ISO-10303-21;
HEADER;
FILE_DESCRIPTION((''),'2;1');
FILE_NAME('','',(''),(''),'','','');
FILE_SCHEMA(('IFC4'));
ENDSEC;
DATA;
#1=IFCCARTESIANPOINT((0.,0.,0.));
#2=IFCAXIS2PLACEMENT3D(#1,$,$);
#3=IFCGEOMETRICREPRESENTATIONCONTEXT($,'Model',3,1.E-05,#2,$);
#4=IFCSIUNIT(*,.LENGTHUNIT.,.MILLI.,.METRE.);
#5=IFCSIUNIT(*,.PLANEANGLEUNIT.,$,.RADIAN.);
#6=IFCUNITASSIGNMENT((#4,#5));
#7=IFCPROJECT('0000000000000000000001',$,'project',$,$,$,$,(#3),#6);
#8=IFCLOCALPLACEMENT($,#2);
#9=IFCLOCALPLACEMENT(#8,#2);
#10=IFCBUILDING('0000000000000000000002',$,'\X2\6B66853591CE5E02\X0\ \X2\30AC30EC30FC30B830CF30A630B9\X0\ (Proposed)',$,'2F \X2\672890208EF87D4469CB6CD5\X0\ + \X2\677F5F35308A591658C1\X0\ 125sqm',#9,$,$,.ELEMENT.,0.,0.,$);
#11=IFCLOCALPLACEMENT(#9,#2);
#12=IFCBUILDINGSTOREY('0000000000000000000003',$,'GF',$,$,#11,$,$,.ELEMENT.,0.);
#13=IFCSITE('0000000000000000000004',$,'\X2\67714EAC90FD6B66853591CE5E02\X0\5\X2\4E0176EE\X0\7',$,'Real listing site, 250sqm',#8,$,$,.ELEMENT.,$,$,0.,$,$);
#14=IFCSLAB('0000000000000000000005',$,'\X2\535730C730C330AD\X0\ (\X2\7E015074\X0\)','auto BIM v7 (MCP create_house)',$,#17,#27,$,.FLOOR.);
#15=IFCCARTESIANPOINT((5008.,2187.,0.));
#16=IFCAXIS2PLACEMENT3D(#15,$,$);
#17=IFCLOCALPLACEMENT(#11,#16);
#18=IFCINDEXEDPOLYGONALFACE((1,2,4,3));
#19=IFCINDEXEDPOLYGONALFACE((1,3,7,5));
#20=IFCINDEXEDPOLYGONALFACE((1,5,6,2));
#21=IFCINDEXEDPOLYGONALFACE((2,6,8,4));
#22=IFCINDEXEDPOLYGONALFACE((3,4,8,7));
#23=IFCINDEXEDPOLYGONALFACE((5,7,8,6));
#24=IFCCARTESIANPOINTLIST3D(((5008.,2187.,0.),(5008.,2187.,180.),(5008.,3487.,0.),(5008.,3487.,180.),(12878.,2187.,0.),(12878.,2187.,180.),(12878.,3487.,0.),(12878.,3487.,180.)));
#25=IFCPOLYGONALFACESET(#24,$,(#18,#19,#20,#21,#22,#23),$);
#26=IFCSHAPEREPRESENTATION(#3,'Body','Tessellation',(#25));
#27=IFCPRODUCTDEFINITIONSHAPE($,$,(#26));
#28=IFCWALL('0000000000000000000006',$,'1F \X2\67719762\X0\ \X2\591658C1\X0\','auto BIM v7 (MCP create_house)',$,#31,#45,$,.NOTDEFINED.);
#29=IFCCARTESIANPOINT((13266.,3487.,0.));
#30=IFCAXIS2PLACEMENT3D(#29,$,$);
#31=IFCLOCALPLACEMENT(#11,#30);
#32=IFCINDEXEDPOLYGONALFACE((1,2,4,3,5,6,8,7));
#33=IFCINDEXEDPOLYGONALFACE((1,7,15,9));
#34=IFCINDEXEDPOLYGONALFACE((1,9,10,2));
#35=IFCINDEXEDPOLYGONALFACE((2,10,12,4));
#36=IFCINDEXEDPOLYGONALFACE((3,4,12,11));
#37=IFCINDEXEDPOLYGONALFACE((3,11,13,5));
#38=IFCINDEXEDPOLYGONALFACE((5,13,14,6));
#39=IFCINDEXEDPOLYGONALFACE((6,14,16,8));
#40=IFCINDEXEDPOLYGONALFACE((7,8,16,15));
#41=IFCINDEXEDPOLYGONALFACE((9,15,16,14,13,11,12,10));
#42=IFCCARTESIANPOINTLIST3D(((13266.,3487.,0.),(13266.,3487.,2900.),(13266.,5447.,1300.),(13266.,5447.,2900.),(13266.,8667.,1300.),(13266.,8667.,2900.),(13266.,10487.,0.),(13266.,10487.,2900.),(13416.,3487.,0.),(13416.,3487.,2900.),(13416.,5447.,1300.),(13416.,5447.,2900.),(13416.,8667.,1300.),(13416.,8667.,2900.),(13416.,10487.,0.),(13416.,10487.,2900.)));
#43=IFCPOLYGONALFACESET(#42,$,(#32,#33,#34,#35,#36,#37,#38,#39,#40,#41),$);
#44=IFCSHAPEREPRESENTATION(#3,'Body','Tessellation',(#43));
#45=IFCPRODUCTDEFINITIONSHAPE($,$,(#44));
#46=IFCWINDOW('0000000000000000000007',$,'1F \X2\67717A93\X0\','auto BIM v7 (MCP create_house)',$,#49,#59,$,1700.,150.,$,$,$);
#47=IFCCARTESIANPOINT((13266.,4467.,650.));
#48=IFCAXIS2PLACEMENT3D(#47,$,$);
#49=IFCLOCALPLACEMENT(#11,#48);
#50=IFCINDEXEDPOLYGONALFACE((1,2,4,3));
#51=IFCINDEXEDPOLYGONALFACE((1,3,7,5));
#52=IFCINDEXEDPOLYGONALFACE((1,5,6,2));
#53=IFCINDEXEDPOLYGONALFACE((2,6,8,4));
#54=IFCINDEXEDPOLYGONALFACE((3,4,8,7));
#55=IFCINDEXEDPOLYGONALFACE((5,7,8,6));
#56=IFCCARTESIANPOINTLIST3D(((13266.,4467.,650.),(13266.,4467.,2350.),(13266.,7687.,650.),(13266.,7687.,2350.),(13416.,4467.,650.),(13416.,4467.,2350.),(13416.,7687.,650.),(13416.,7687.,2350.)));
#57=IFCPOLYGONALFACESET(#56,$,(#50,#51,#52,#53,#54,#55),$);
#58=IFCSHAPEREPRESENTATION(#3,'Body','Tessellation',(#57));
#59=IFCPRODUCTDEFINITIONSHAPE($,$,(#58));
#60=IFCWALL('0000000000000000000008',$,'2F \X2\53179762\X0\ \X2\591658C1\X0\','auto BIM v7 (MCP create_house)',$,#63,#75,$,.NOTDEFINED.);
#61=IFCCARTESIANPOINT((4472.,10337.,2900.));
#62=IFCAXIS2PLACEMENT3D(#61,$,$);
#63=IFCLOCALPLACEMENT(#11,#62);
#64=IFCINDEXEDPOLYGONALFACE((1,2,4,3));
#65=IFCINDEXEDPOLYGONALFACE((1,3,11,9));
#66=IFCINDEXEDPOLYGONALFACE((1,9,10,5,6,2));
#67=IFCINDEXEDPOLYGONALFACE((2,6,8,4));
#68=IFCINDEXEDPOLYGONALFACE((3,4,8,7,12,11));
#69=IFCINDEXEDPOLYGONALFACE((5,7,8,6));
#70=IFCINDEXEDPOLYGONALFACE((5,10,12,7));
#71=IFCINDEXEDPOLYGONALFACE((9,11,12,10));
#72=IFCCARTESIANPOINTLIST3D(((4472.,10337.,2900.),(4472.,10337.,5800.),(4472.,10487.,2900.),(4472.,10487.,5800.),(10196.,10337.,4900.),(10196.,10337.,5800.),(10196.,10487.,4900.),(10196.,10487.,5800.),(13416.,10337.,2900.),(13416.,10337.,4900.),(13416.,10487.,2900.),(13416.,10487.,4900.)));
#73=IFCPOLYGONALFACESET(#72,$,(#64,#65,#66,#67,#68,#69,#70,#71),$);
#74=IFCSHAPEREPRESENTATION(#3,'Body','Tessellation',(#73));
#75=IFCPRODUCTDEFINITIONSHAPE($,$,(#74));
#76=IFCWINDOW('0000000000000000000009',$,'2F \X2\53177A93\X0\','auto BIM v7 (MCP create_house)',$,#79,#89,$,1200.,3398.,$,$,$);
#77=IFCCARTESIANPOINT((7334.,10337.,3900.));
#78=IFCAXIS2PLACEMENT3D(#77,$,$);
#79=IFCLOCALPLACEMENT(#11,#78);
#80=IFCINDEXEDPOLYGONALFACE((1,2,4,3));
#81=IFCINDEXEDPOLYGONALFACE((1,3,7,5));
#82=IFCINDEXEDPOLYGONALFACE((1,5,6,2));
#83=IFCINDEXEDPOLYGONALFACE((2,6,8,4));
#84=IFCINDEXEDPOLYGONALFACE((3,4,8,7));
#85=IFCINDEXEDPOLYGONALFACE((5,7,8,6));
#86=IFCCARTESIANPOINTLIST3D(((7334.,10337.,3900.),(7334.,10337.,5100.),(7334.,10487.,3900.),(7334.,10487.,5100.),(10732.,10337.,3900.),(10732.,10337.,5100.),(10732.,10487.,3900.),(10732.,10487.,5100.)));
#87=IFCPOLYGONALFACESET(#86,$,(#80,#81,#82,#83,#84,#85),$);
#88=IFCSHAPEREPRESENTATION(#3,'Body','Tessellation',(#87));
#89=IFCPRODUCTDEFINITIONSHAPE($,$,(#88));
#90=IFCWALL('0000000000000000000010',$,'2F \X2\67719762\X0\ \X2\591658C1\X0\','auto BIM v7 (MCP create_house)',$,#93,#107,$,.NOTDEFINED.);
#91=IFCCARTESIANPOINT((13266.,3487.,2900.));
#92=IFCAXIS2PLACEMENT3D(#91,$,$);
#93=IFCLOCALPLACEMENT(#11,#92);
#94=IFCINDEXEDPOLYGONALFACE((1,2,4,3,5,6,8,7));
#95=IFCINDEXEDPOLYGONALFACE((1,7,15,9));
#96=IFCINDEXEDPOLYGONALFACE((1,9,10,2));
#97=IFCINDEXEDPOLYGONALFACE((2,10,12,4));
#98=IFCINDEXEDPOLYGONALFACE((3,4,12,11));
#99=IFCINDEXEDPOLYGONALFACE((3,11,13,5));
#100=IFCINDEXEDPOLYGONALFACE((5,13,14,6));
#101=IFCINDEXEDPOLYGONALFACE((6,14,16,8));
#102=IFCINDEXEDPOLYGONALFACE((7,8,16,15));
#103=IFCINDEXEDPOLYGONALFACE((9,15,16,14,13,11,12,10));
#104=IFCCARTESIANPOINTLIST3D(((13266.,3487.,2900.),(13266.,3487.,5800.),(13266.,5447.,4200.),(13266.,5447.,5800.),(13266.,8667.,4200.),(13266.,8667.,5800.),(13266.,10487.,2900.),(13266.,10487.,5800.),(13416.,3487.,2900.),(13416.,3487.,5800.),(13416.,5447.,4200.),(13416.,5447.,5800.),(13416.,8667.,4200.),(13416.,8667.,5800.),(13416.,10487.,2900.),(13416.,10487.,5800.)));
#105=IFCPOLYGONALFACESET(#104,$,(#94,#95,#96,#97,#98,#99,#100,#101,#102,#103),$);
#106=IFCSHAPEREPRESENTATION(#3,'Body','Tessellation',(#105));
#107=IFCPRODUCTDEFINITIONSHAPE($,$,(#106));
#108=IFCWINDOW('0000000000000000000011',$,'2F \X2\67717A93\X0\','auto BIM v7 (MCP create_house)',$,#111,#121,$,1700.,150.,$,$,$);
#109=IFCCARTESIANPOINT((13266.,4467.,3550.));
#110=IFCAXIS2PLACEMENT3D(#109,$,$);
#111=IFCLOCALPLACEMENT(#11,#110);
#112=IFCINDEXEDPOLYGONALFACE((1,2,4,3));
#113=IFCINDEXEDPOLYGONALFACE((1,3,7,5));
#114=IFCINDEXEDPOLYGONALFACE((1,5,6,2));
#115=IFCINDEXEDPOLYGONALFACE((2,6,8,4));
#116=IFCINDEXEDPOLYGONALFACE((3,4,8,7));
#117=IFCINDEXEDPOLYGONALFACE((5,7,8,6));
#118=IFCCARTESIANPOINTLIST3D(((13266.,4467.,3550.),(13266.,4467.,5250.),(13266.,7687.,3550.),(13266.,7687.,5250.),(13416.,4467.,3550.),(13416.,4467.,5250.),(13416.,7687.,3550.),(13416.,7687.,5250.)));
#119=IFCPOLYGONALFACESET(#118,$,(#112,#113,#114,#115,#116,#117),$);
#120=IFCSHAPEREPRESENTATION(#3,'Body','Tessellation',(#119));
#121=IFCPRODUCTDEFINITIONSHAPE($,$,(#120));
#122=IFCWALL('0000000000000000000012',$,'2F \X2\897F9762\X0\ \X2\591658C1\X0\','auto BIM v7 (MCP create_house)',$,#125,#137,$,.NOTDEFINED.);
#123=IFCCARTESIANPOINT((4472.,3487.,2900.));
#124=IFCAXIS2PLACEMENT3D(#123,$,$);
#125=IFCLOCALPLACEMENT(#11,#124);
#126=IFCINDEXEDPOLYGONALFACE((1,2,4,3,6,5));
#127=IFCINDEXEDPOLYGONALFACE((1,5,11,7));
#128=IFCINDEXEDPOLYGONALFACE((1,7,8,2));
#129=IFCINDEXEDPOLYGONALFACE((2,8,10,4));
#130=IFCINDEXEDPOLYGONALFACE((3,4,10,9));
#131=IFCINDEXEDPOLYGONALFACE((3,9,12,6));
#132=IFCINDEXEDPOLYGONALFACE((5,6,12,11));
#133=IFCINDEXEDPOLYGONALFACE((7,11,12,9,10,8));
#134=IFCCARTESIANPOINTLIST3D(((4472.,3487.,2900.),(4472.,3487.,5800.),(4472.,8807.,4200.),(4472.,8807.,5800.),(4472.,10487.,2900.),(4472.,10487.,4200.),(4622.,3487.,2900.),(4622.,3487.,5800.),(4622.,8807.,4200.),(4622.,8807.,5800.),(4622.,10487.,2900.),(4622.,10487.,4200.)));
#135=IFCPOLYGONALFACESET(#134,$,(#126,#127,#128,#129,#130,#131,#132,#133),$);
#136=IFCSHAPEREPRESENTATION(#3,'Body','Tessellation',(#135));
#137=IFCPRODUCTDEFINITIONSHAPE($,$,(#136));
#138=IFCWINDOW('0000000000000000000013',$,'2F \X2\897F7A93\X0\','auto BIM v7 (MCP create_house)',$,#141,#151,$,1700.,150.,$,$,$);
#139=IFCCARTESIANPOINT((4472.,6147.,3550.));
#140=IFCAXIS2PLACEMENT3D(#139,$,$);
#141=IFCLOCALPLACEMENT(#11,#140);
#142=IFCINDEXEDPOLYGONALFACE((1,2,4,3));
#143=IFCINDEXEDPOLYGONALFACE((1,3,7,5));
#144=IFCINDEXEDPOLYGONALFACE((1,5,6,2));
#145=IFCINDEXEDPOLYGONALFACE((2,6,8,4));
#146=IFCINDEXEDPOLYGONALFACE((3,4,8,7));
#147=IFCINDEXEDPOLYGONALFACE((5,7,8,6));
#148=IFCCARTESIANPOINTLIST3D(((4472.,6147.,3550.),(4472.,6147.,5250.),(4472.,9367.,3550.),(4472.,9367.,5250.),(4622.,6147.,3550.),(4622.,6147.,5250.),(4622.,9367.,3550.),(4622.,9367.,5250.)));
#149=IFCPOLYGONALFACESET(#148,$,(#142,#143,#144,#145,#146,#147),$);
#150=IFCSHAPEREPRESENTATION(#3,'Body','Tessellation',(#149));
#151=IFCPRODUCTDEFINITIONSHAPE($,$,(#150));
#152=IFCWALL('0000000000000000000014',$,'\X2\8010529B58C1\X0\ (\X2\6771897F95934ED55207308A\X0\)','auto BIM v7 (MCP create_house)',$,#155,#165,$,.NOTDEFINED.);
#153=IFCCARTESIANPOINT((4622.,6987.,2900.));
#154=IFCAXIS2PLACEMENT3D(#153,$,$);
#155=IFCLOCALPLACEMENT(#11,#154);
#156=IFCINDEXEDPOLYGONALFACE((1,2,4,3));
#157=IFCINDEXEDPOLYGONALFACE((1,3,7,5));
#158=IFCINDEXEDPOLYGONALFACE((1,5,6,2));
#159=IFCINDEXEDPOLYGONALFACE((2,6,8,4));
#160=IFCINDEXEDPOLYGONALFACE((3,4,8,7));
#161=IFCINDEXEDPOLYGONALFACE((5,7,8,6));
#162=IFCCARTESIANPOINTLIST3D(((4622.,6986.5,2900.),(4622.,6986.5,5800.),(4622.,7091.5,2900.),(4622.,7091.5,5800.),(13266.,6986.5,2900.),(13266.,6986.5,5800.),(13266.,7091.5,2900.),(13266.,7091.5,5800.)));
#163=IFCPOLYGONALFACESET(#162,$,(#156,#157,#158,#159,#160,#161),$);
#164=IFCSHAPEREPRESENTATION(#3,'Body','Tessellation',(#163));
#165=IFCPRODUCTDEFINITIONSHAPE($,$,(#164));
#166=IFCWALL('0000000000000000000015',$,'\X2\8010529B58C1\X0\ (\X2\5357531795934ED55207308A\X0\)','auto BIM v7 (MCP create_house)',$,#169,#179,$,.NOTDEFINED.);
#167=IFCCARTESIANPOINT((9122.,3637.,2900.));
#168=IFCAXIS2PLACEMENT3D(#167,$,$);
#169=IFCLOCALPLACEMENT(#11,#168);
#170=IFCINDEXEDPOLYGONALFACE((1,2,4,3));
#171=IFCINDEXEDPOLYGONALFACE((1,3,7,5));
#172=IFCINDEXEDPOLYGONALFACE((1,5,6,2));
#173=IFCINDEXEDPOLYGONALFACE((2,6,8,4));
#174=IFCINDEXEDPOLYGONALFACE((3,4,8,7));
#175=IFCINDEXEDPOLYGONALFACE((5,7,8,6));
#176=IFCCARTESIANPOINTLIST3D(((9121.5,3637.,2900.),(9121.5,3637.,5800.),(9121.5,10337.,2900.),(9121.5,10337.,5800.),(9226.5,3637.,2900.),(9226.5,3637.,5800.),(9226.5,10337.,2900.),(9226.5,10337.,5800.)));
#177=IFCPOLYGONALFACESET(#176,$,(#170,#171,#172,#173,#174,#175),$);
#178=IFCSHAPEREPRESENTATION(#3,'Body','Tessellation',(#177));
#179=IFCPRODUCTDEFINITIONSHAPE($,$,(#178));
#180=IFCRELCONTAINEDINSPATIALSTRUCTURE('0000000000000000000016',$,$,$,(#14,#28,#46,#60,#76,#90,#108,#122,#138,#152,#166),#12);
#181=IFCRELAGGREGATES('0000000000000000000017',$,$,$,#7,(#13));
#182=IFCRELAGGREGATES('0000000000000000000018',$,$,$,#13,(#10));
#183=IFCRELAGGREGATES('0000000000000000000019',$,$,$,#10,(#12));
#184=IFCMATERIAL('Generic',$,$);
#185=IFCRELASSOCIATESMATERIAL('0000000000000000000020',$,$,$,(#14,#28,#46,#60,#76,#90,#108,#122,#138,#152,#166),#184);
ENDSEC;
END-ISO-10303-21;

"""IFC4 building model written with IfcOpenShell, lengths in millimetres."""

from ifc_helpers import new_model, si_unit, frame, frame_2d, origin, place, context, project, spatial, rectangle, extrude, material, element, fill, save


model = new_model("IFC4")

# Units and contexts
model_context = context("Model", 3, precision=1e-05, world=origin())
ifc_project = project(units=[si_unit("LENGTHUNIT", "METRE", prefix="MILLI"), si_unit("PLANEANGLEUNIT", "RADIAN")], contexts=[model_context])

# Site, building, storey
site_placement = place(None, origin())
site = spatial("IfcSite", under=ifc_project, at=site_placement, Name="東京都武蔵野市5丁目7", ObjectType="Real listing site, 250sqm", CompositionType="ELEMENT", RefElevation=0.0)
building_placement = place(site_placement, origin())
building = spatial("IfcBuilding", under=site, at=building_placement, Name="武蔵野市 ガレージハウス (Proposed)", ObjectType="2F 木造軸組構法 + 板張り外壁 125sqm", CompositionType="ELEMENT", ElevationOfRefHeight=0.0, ElevationOfTerrain=0.0)
storey_placement = place(building_placement, origin())
storey = spatial("IfcBuildingStorey", under=building, at=storey_placement, Name="GF", CompositionType="ELEMENT", Elevation=0.0)

# Slab
ifc_material = material(Name="Generic")
slab_placement = place(storey_placement, frame((5008.0, 2187.0, 0.0)))
element("IfcSlab", 1, at=slab_placement, inside=storey, material=ifc_material, Name="南デッキ (縁側)", Description="auto BIM v7 (MCP create_house)", PredefinedType="FLOOR", context=model_context, shape_type="SweptSolid", body=[
    extrude(rectangle(XDim=7870.0, YDim=1300.0, at=frame_2d((3935.0, 650.0))), frame((5008.0, 2187.0, 0.0)), (0.0, 0.0, 1.0), 180.0),
])

# Wall, opening, window
wall_1_placement = place(storey_placement, frame((13266.0, 3487.0, 0.0)))
wall_1 = element("IfcWall", 2, at=wall_1_placement, inside=storey, material=ifc_material, Name="1F 東面 外壁", Description="auto BIM v7 (MCP create_house)", PredefinedType="NOTDEFINED", context=model_context, shape_type="SweptSolid", body=[
    extrude(rectangle(XDim=150.0, YDim=7000.0, at=frame_2d((75.0, 3500.0))), frame((13266.0, 3487.0, 0.0)), (0.0, 0.0, 1.0), 2900.0),
])
opening_1_placement = place(storey_placement, frame((13266.0, 4467.0, 650.0)))
opening_1 = element("IfcOpeningElement", 3, at=opening_1_placement, cuts=wall_1, PredefinedType="NOTDEFINED", context=model_context, shape_type="SweptSolid", body=[
    extrude(rectangle(XDim=150.0, YDim=3220.0, at=frame_2d((75.0, 1610.0))), frame((13266.0, 4467.0, 650.0)), (0.0, 0.0, 1.0), 1700.0),
])
window_1_placement = place(storey_placement, frame((13266.0, 4467.0, 650.0)))
window_1 = element("IfcWindow", 4, at=window_1_placement, inside=storey, material=ifc_material, Name="1F 東窓", Description="auto BIM v7 (MCP create_house)", OverallHeight=1700.0, OverallWidth=150.0, context=model_context, shape_type="SweptSolid", body=[
    extrude(rectangle(XDim=150.0, YDim=3220.0, at=frame_2d((75.0, 1610.0))), frame((13266.0, 4467.0, 650.0)), (0.0, 0.0, 1.0), 1700.0),
])
fill(opening_1, window_1)

# Walls, openings, windows
wall_2_placement = place(storey_placement, frame((4472.0, 10337.0, 2900.0)))
wall_2 = element("IfcWall", 5, at=wall_2_placement, inside=storey, material=ifc_material, Name="2F 北面 外壁", Description="auto BIM v7 (MCP create_house)", PredefinedType="NOTDEFINED", context=model_context, shape_type="SweptSolid", body=[
    extrude(rectangle(XDim=8944.0, YDim=150.0, at=frame_2d((4472.0, 75.0))), frame((4472.0, 10337.0, 2900.0)), (0.0, 0.0, 1.0), 2900.0),
])
opening_2_placement = place(storey_placement, frame((7334.0, 10337.0, 3900.0)))
opening_2 = element("IfcOpeningElement", 6, at=opening_2_placement, cuts=wall_2, PredefinedType="NOTDEFINED", context=model_context, shape_type="SweptSolid", body=[
    extrude(rectangle(XDim=3398.0, YDim=150.0, at=frame_2d((1699.0, 75.0))), frame((7334.0, 10337.0, 3900.0)), (0.0, 0.0, 1.0), 1200.0),
])
window_2_placement = place(storey_placement, frame((7334.0, 10337.0, 3900.0)))
window_2 = element("IfcWindow", 7, at=window_2_placement, inside=storey, material=ifc_material, Name="2F 北窓", Description="auto BIM v7 (MCP create_house)", OverallHeight=1200.0, OverallWidth=3398.0, context=model_context, shape_type="SweptSolid", body=[
    extrude(rectangle(XDim=3398.0, YDim=150.0, at=frame_2d((1699.0, 75.0))), frame((7334.0, 10337.0, 3900.0)), (0.0, 0.0, 1.0), 1200.0),
])
fill(opening_2, window_2)
wall_3_placement = place(storey_placement, frame((13266.0, 3487.0, 2900.0)))
wall_3 = element("IfcWall", 8, at=wall_3_placement, inside=storey, material=ifc_material, Name="2F 東面 外壁", Description="auto BIM v7 (MCP create_house)", PredefinedType="NOTDEFINED", context=model_context, shape_type="SweptSolid", body=[
    extrude(rectangle(XDim=150.0, YDim=7000.0, at=frame_2d((75.0, 3500.0))), frame((13266.0, 3487.0, 2900.0)), (0.0, 0.0, 1.0), 2900.0),
])
opening_3_placement = place(storey_placement, frame((13266.0, 4467.0, 3550.0)))
opening_3 = element("IfcOpeningElement", 9, at=opening_3_placement, cuts=wall_3, PredefinedType="NOTDEFINED", context=model_context, shape_type="SweptSolid", body=[
    extrude(rectangle(XDim=150.0, YDim=3220.0, at=frame_2d((75.0, 1610.0))), frame((13266.0, 4467.0, 3550.0)), (0.0, 0.0, 1.0), 1700.0),
])
window_3_placement = place(storey_placement, frame((13266.0, 4467.0, 3550.0)))
window_3 = element("IfcWindow", 10, at=window_3_placement, inside=storey, material=ifc_material, Name="2F 東窓", Description="auto BIM v7 (MCP create_house)", OverallHeight=1700.0, OverallWidth=150.0, context=model_context, shape_type="SweptSolid", body=[
    extrude(rectangle(XDim=150.0, YDim=3220.0, at=frame_2d((75.0, 1610.0))), frame((13266.0, 4467.0, 3550.0)), (0.0, 0.0, 1.0), 1700.0),
])
fill(opening_3, window_3)
wall_4_placement = place(storey_placement, frame((4472.0, 3487.0, 2900.0)))
wall_4 = element("IfcWall", 11, at=wall_4_placement, inside=storey, material=ifc_material, Name="2F 西面 外壁", Description="auto BIM v7 (MCP create_house)", PredefinedType="NOTDEFINED", context=model_context, shape_type="SweptSolid", body=[
    extrude(rectangle(XDim=150.0, YDim=7000.0, at=frame_2d((75.0, 3500.0))), frame((4472.0, 3487.0, 2900.0)), (0.0, 0.0, 1.0), 2900.0),
])
opening_4_placement = place(storey_placement, frame((4472.0, 6147.0, 3550.0)))
opening_4 = element("IfcOpeningElement", 12, at=opening_4_placement, cuts=wall_4, PredefinedType="NOTDEFINED", context=model_context, shape_type="SweptSolid", body=[
    extrude(rectangle(XDim=150.0, YDim=3220.0, at=frame_2d((75.0, 1610.0))), frame((4472.0, 6147.0, 3550.0)), (0.0, 0.0, 1.0), 1700.0),
])
window_4_placement = place(storey_placement, frame((4472.0, 6147.0, 3550.0)))
window_4 = element("IfcWindow", 13, at=window_4_placement, inside=storey, material=ifc_material, Name="2F 西窓", Description="auto BIM v7 (MCP create_house)", OverallHeight=1700.0, OverallWidth=150.0, context=model_context, shape_type="SweptSolid", body=[
    extrude(rectangle(XDim=150.0, YDim=3220.0, at=frame_2d((75.0, 1610.0))), frame((4472.0, 6147.0, 3550.0)), (0.0, 0.0, 1.0), 1700.0),
])
fill(opening_4, window_4)

# Walls
wall_5_placement = place(storey_placement, frame((4622.0, 6987.0, 2900.0)))
element("IfcWall", 14, at=wall_5_placement, inside=storey, material=ifc_material, Name="耐力壁 (東西間仕切り)", Description="auto BIM v7 (MCP create_house)", PredefinedType="NOTDEFINED", context=model_context, shape_type="SweptSolid", body=[
    extrude(rectangle(XDim=8644.0, YDim=105.0, at=frame_2d((4322.0, 52.0))), frame((4622.0, 6987.0, 2900.0)), (0.0, 0.0, 1.0), 2900.0),
])
wall_6_placement = place(storey_placement, frame((9122.0, 3637.0, 2900.0)))
element("IfcWall", 15, at=wall_6_placement, inside=storey, material=ifc_material, Name="耐力壁 (南北間仕切り)", Description="auto BIM v7 (MCP create_house)", PredefinedType="NOTDEFINED", context=model_context, shape_type="SweptSolid", body=[
    extrude(rectangle(XDim=105.0, YDim=6700.0, at=frame_2d((52.0, 3350.0))), frame((9122.0, 3637.0, 2900.0)), (0.0, 0.0, 1.0), 2900.0),
])

save(model, "model.ifc")
